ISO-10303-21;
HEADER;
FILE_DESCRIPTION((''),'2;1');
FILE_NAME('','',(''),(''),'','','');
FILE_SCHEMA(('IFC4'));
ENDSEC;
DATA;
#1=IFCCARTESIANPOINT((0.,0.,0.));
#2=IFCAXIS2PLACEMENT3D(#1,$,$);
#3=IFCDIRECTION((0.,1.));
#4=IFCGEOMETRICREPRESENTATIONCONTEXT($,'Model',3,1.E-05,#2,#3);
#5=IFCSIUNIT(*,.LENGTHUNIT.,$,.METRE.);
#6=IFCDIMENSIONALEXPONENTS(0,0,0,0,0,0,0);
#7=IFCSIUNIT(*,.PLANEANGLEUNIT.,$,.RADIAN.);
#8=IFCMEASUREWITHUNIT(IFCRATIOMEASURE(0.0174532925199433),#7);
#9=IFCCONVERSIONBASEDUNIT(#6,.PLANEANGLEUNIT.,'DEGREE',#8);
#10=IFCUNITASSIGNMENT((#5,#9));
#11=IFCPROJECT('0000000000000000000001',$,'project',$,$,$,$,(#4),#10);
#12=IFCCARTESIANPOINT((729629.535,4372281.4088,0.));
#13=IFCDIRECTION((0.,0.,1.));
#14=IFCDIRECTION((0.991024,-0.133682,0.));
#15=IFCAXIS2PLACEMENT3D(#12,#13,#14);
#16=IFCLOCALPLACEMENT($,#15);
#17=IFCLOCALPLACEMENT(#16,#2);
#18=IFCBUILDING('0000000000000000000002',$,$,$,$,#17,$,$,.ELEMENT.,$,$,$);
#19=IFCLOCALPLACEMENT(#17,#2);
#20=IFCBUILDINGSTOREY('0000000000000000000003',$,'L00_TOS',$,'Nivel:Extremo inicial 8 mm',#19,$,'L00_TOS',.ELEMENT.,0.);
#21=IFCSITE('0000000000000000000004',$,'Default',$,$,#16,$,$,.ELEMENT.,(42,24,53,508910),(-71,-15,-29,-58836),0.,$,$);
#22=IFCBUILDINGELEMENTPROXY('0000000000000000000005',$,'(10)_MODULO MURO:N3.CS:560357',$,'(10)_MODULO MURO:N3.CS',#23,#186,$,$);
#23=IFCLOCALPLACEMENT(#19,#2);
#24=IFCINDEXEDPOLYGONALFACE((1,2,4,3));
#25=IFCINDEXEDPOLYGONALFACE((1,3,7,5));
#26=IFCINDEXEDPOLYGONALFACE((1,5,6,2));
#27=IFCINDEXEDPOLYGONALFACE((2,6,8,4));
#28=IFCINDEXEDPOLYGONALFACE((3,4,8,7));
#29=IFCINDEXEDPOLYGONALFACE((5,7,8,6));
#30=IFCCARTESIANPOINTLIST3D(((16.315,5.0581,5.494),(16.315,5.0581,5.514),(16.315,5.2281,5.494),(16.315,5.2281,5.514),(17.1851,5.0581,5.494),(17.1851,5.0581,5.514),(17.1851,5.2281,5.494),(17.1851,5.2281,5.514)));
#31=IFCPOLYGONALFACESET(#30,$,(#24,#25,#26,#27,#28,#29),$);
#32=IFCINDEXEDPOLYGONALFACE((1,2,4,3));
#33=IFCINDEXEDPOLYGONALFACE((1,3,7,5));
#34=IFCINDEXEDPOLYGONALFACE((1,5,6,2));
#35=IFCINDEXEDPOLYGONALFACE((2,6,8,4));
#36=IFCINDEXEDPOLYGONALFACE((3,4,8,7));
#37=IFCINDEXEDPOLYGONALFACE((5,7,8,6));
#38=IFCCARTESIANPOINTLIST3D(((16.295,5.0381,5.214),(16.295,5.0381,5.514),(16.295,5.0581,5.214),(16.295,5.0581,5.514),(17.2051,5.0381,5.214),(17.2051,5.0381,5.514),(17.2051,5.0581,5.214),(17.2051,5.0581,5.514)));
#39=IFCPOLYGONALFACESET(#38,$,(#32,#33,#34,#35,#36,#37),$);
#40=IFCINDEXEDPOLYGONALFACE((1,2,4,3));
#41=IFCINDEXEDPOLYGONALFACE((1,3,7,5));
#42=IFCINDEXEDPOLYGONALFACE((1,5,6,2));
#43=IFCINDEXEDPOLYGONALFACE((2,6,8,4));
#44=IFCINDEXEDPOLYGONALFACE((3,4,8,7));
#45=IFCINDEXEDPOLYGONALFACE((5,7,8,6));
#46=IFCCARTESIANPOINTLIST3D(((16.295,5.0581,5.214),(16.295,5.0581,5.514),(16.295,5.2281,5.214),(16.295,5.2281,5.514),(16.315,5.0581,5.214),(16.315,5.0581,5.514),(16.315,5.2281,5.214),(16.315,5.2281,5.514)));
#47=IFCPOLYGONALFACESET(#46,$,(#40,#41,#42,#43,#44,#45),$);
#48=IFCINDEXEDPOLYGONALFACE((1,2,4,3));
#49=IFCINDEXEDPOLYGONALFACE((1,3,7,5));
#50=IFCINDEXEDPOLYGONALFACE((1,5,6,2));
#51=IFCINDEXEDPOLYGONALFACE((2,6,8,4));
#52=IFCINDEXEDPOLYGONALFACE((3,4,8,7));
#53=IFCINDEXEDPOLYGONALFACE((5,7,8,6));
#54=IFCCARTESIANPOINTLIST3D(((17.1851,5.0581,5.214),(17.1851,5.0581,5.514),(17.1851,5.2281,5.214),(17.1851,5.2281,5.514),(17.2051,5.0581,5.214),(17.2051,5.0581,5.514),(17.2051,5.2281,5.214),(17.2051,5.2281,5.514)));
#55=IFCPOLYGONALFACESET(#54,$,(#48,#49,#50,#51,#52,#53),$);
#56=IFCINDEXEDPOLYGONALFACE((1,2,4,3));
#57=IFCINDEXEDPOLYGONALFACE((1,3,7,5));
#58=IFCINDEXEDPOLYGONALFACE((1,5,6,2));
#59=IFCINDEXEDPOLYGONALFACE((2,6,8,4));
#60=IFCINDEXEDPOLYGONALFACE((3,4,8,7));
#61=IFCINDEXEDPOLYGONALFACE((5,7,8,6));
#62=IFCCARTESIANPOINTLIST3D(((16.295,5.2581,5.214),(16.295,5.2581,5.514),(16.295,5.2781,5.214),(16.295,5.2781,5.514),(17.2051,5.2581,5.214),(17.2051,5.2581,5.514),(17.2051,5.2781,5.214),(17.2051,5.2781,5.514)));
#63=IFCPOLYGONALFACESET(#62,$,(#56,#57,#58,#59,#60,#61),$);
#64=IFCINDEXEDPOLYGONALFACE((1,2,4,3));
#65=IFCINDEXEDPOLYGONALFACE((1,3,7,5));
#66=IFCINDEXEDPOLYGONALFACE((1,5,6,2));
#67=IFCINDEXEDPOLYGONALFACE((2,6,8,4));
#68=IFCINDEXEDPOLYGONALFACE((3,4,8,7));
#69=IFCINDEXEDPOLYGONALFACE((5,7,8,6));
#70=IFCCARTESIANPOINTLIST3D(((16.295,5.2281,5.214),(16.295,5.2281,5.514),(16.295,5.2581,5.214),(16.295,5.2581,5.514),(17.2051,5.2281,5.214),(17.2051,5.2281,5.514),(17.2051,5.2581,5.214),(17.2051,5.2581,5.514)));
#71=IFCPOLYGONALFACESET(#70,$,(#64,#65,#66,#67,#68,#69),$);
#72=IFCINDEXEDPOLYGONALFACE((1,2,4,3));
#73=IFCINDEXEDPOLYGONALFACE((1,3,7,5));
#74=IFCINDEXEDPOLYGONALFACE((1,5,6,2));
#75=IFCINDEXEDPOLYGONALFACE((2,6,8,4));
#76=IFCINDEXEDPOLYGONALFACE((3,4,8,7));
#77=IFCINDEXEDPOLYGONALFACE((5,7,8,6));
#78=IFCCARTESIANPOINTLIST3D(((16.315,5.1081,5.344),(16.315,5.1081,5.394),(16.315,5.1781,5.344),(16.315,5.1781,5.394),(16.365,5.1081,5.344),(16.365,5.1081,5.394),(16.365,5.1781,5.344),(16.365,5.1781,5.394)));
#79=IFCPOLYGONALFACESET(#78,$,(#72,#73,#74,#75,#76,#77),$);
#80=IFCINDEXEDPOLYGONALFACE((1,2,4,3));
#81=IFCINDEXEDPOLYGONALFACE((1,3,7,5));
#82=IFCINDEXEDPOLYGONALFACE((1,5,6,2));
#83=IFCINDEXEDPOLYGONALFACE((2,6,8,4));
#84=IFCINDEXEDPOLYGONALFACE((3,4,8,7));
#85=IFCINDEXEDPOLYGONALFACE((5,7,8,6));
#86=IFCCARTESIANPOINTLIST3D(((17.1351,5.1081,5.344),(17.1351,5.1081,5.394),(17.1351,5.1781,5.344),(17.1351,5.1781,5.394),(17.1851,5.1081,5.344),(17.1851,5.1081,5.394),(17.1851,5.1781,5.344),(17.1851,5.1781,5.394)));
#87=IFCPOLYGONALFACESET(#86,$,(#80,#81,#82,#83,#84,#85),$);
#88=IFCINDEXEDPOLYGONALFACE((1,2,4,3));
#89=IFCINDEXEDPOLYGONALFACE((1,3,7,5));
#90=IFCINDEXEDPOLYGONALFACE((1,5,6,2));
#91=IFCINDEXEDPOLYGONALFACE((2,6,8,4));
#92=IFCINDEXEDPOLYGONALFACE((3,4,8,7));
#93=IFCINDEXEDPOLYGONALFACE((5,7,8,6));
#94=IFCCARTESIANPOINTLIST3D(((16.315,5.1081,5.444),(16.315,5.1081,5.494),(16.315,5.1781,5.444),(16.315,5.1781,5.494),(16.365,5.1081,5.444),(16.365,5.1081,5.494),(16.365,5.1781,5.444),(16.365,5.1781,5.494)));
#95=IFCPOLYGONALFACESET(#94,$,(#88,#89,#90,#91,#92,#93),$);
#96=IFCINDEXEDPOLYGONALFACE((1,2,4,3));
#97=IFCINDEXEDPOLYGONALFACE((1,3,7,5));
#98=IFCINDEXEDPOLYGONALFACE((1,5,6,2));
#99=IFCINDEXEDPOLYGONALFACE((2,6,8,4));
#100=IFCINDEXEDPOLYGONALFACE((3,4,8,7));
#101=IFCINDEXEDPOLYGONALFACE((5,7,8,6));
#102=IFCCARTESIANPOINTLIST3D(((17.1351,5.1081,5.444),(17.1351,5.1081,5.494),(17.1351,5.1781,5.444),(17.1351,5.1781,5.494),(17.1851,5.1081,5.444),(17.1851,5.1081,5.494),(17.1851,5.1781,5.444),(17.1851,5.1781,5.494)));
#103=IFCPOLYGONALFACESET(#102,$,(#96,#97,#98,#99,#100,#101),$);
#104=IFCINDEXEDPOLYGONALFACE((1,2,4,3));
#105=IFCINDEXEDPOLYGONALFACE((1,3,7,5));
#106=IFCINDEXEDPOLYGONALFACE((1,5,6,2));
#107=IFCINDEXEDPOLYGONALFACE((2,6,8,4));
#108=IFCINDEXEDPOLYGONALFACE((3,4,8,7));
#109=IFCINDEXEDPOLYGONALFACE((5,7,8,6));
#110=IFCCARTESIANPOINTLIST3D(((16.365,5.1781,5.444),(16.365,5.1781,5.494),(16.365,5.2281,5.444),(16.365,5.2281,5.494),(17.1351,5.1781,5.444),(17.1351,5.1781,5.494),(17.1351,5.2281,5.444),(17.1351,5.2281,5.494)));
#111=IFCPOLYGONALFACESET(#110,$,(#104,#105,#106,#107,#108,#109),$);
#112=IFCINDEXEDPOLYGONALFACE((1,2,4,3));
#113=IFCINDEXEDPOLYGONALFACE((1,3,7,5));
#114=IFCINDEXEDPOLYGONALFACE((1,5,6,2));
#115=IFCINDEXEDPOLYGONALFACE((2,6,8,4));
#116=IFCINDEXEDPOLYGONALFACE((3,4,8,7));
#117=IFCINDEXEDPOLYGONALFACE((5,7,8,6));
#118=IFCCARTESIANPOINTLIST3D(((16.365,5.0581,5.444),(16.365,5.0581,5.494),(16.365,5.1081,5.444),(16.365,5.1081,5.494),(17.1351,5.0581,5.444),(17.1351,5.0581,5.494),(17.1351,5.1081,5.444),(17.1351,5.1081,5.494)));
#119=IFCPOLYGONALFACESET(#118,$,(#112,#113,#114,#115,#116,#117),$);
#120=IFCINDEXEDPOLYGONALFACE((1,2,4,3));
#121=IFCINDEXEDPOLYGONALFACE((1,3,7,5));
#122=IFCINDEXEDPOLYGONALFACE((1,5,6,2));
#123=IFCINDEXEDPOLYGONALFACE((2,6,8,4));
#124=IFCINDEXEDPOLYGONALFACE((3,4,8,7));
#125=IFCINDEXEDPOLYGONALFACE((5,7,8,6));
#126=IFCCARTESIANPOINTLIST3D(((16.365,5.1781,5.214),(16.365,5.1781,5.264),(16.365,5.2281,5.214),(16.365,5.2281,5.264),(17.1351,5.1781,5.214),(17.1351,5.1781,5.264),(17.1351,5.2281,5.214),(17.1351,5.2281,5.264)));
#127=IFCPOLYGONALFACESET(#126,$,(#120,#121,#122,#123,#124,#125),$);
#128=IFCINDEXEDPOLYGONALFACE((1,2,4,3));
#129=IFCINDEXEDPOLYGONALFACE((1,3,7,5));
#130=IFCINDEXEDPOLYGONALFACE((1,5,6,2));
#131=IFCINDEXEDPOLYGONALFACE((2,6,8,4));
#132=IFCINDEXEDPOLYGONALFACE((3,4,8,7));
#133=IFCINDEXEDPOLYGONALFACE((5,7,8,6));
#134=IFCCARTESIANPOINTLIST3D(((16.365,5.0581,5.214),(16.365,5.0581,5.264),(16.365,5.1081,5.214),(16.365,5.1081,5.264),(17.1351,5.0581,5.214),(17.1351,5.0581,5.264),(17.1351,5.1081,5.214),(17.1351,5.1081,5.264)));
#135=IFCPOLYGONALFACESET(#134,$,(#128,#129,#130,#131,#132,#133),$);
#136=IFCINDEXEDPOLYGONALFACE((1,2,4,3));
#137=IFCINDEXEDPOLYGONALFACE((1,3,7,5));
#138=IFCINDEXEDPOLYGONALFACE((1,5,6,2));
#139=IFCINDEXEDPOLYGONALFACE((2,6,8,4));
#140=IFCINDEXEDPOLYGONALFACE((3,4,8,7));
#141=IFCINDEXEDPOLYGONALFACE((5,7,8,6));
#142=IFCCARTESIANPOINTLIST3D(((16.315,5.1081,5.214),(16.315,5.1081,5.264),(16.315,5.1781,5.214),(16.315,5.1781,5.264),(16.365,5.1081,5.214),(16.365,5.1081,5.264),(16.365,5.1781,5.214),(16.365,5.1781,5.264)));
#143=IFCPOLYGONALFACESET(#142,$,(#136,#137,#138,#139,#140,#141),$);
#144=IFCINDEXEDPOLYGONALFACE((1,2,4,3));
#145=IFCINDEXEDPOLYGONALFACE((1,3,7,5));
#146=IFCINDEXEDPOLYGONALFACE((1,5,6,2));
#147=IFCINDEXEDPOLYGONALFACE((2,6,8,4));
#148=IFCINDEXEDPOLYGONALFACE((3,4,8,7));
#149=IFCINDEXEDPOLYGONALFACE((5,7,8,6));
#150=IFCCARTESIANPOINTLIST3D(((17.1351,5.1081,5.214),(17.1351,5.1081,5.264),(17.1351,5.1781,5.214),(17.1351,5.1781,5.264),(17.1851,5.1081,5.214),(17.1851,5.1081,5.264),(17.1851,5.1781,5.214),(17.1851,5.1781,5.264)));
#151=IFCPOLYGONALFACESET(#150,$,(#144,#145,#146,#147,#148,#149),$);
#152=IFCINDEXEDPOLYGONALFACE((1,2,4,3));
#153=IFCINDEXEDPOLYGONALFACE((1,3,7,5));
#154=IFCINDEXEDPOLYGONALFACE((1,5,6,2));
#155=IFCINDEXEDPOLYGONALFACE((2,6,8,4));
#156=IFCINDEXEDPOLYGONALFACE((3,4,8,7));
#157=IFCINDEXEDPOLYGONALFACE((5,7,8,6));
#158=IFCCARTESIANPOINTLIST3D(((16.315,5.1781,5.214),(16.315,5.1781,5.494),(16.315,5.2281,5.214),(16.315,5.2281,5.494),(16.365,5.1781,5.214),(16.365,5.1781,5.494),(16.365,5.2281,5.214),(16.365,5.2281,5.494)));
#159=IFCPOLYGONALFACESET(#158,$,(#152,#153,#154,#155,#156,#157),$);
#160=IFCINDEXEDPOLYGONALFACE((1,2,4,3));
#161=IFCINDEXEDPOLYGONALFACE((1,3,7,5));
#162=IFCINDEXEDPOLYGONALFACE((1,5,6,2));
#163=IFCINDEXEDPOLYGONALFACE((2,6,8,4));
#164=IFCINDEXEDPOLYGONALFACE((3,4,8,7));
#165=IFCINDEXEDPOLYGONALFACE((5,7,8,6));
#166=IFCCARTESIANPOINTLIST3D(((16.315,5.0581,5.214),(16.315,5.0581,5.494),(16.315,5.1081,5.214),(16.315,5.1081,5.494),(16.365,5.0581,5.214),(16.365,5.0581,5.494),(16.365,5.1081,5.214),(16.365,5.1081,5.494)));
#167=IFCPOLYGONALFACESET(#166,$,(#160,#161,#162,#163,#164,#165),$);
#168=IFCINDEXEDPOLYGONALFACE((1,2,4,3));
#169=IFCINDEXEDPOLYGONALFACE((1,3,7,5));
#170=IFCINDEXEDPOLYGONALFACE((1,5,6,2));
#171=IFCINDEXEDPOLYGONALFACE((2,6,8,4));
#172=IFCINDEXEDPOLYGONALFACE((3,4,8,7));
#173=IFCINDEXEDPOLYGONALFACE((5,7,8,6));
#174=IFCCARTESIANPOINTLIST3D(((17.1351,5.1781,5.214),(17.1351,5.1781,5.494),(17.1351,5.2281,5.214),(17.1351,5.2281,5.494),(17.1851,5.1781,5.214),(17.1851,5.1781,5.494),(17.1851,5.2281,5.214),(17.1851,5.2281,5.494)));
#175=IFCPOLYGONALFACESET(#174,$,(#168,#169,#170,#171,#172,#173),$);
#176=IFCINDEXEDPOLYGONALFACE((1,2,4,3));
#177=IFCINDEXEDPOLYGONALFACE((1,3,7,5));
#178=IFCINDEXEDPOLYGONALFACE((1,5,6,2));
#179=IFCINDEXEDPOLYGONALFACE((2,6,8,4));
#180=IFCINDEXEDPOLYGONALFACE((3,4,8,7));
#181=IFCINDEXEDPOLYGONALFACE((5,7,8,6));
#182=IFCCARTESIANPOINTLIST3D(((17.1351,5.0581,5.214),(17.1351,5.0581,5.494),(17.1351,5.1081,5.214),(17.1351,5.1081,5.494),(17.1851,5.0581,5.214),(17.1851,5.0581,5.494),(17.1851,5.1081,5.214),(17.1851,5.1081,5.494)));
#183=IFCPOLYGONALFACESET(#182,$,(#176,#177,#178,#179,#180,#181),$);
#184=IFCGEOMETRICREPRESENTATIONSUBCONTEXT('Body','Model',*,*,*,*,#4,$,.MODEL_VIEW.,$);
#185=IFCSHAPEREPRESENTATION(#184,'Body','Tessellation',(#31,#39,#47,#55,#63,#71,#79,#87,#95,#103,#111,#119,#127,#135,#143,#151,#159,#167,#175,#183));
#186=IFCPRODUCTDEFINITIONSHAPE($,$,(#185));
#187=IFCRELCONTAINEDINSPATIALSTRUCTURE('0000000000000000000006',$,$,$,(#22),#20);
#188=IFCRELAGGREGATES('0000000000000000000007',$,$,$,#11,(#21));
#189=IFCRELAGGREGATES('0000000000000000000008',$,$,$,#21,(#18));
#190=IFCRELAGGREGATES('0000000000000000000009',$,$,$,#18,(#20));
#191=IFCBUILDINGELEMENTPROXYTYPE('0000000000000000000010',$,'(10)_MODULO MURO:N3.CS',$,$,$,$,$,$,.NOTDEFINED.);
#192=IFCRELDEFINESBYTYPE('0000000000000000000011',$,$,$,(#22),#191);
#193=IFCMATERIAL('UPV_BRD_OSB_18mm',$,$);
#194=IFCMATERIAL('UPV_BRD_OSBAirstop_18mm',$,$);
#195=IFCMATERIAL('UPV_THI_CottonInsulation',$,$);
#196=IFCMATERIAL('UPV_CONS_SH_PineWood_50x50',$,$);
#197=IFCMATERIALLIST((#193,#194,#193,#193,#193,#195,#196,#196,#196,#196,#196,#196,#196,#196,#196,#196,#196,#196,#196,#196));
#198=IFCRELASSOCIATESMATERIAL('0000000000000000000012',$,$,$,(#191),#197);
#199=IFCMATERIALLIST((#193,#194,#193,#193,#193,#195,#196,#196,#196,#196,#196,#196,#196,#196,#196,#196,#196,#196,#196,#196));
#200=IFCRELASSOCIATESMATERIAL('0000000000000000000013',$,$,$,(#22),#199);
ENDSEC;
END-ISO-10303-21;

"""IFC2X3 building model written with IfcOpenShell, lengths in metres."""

from ifc_helpers import new_model, entity, si_unit, converted_unit, direction, frame, frame_2d, origin, origin_2d_with_axis, place, context, subcontext, project, spatial, rectangle, extrude, source, transform, mapped, material, material_list, type_object, type_shapes, element, save


model = new_model("IFC2X3")

# Units and contexts
model_context = context("Model", 3, precision=1e-05, world=origin(), true_north=direction((0.0, 1.0)))
body_context = subcontext(model_context, "Body", "Model", "MODEL_VIEW")
ifc_project = project(units=[si_unit("LENGTHUNIT", "METRE"), converted_unit("PLANEANGLEUNIT", "DEGREE", entity("IfcRatioMeasure", 0.0174532925199433), si_unit("PLANEANGLEUNIT", "RADIAN"), dimensions=[0, 0, 0, 0, 0, 0, 0])], contexts=[model_context])

# Site, building, storey
site_placement = place(None, frame((729629.535, 4372281.4088, 0.0), z_axis=(0.0, 0.0, 1.0), x_axis=(0.991024, -0.133682, 0.0)))
site = spatial("IfcSite", under=ifc_project, at=site_placement, Name="Default", CompositionType="ELEMENT", RefLatitude=(42, 24, 53, 508910), RefLongitude=(-71, -15, -29, -58836), RefElevation=0.0)
building_placement = place(site_placement, origin())
building = spatial("IfcBuilding", under=site, at=building_placement, CompositionType="ELEMENT")
storey_placement = place(building_placement, origin())
storey = spatial("IfcBuildingStorey", under=building, at=storey_placement, Name="L00_TOS", ObjectType="Nivel:Extremo inicial 8 mm", LongName="L00_TOS", CompositionType="ELEMENT", Elevation=0.0)

# Building element proxy
ifc_material_1 = material(Name="UPV_BRD_OSBAirstop_18mm")
ifc_material_2 = material(Name="UPV_BRD_OSB_18mm")
ifc_material_3 = material(Name="UPV_THI_CottonInsulation")
ifc_material_4 = material(Name="UPV_CONS_SH_PineWood_50x50")
ifc_material_list_1 = material_list([ifc_material_2, ifc_material_1, ifc_material_2, ifc_material_2, ifc_material_2, ifc_material_3, ifc_material_4, ifc_material_4, ifc_material_4, ifc_material_4, ifc_material_4, ifc_material_4, ifc_material_4, ifc_material_4, ifc_material_4, ifc_material_4, ifc_material_4, ifc_material_4, ifc_material_4, ifc_material_4])
ifc_material_list_2 = material_list([ifc_material_2, ifc_material_1, ifc_material_2, ifc_material_2, ifc_material_2, ifc_material_3, ifc_material_4, ifc_material_4, ifc_material_4, ifc_material_4, ifc_material_4, ifc_material_4, ifc_material_4, ifc_material_4, ifc_material_4, ifc_material_4, ifc_material_4, ifc_material_4, ifc_material_4, ifc_material_4])
building_element_proxy_type_1 = type_object("IfcBuildingElementProxyType", Name="(10)_MODULO MURO:N3.CS", PredefinedType="NOTDEFINED", material=ifc_material_list_2)
shared_shape_1 = source(origin(), body_context, "Body", "SweptSolid", [
    extrude(rectangle(XDim=0.8701, YDim=0.17, at=origin_2d_with_axis()), frame((0.0, 0.0, 0.28), z_axis=(0.0, 0.0, 1.0), x_axis=(-1.0, 0.0, 0.0)), (0.0, 0.0, 1.0), 0.02),
    extrude(rectangle(XDim=0.9101, YDim=0.02, at=origin_2d_with_axis()), frame((0.0, -0.095, 0.0)), (0.0, 0.0, 1.0), 0.3),
    extrude(rectangle(XDim=0.17, YDim=0.02, at=frame_2d((0.0, 0.0), x_axis=(1.0, 0.0))), frame((-0.4451, 0.0, 0.0), z_axis=(0.0, 0.0, 1.0), x_axis=(0.0, -1.0, 0.0)), (0.0, 0.0, 1.0), 0.3),
    extrude(rectangle(XDim=0.17, YDim=0.02, at=frame_2d((0.0, 0.0), x_axis=(1.0, 0.0))), frame((0.4451, 0.0, 0.0), z_axis=(0.0, 0.0, 1.0), x_axis=(0.0, -1.0, 0.0)), (0.0, 0.0, 1.0), 0.3),
    extrude(rectangle(XDim=0.9101, YDim=0.02, at=origin_2d_with_axis()), frame((0.0, 0.125, 0.0), z_axis=(0.0, 0.0, 1.0), x_axis=(-1.0, 0.0, 0.0)), (0.0, 0.0, 1.0), 0.3),
    extrude(rectangle(XDim=0.9101, YDim=0.03, at=frame_2d((0.0, 0.0), x_axis=(1.0, 0.0))), frame((0.0, 0.1, 0.0), z_axis=(0.0, 0.0, 1.0), x_axis=(-1.0, 0.0, 0.0)), (0.0, 0.0, 1.0), 0.3),
    extrude(rectangle(XDim=0.07, YDim=0.05, at=frame_2d((0.0, 0.0), x_axis=(1.0, 0.0))), frame((-0.41, 0.0, 0.13), z_axis=(0.0, 0.0, 1.0), x_axis=(0.0, 1.0, 0.0)), (0.0, 0.0, 1.0), 0.05),
    extrude(rectangle(XDim=0.07, YDim=0.05, at=origin_2d_with_axis()), frame((0.41, 0.0, 0.13), z_axis=(0.0, 0.0, 1.0), x_axis=(0.0, 1.0, 0.0)), (0.0, 0.0, 1.0), 0.05),
    extrude(rectangle(XDim=0.07, YDim=0.05, at=frame_2d((0.0, 0.0), x_axis=(1.0, 0.0))), frame((-0.41, 0.0, 0.23), z_axis=(0.0, 0.0, 1.0), x_axis=(0.0, -1.0, 0.0)), (0.0, 0.0, 1.0), 0.05),
    extrude(rectangle(XDim=0.07, YDim=0.05, at=origin_2d_with_axis()), frame((0.41, 0.0, 0.23), z_axis=(0.0, 0.0, 1.0), x_axis=(0.0, -1.0, 0.0)), (0.0, 0.0, 1.0), 0.05),
    extrude(rectangle(XDim=0.7701, YDim=0.05, at=origin_2d_with_axis()), frame((0.0, 0.06, 0.23), z_axis=(0.0, 0.0, 1.0), x_axis=(-1.0, 0.0, 0.0)), (0.0, 0.0, 1.0), 0.05),
    extrude(rectangle(XDim=0.05, YDim=0.7701, at=frame_2d((0.0, 0.0), x_axis=(1.0, 0.0))), frame((0.0, -0.06, 0.23), z_axis=(0.0, 0.0, 1.0), x_axis=(0.0, -1.0, 0.0)), (0.0, 0.0, 1.0), 0.05),
    extrude(rectangle(XDim=0.05, YDim=0.7701, at=origin_2d_with_axis()), frame((0.0, 0.06, 0.0), z_axis=(0.0, 0.0, 1.0), x_axis=(0.0, -1.0, 0.0)), (0.0, 0.0, 1.0), 0.05),
    extrude(rectangle(XDim=0.05, YDim=0.7701, at=frame_2d((0.0, 0.0), x_axis=(1.0, 0.0))), frame((0.0, -0.06, 0.0), z_axis=(0.0, 0.0, 1.0), x_axis=(0.0, -1.0, 0.0)), (0.0, 0.0, 1.0), 0.05),
    extrude(rectangle(XDim=0.07, YDim=0.05, at=frame_2d((0.0, 0.0), x_axis=(1.0, 0.0))), frame((-0.41, 0.0, 0.0), z_axis=(0.0, 0.0, 1.0), x_axis=(0.0, -1.0, 0.0)), (0.0, 0.0, 1.0), 0.05),
    extrude(rectangle(XDim=0.05, YDim=0.07, at=origin_2d_with_axis()), frame((0.41, 0.0, 0.0), z_axis=(0.0, 0.0, 1.0), x_axis=(-1.0, 0.0, 0.0)), (0.0, 0.0, 1.0), 0.05),
    extrude(rectangle(XDim=0.05, YDim=0.05, at=frame_2d((0.0, 0.0), x_axis=(1.0, 0.0))), frame((-0.41, 0.06, 0.0), z_axis=(0.0, 0.0, 1.0), x_axis=(0.0, -1.0, 0.0)), (0.0, 0.0, 1.0), 0.28),
    extrude(rectangle(XDim=0.05, YDim=0.05, at=frame_2d((0.0, 0.0), x_axis=(1.0, 0.0))), frame((-0.41, -0.06, 0.0), z_axis=(0.0, 0.0, 1.0), x_axis=(0.0, -1.0, 0.0)), (0.0, 0.0, 1.0), 0.28),
    extrude(rectangle(XDim=0.05, YDim=0.05, at=origin_2d_with_axis()), frame((0.41, 0.06, 0.0), z_axis=(0.0, 0.0, 1.0), x_axis=(0.0, -1.0, 0.0)), (0.0, 0.0, 1.0), 0.28),
    extrude(rectangle(XDim=0.05, YDim=0.05, at=frame_2d((0.0, 0.0), x_axis=(1.0, 0.0))), frame((0.41, -0.06, 0.0), z_axis=(0.0, 0.0, 1.0), x_axis=(0.0, -1.0, 0.0)), (0.0, 0.0, 1.0), 0.28),
])
type_shapes(building_element_proxy_type_1, [shared_shape_1])
proxy_1_placement = place(storey_placement, frame((16.75, 5.1431, 5.214)))
element("IfcBuildingElementProxy", 1, at=proxy_1_placement, inside=storey, type_object=building_element_proxy_type_1, material=ifc_material_list_1, Name="(10)_MODULO MURO:N3.CS:560357", ObjectType="(10)_MODULO MURO:N3.CS", context=body_context, shape_type="MappedRepresentation", body=[
    mapped(shared_shape_1, transform((0.0, 0.0, 0.0), scale=1.0)),
])

save(model, "model.ifc")
